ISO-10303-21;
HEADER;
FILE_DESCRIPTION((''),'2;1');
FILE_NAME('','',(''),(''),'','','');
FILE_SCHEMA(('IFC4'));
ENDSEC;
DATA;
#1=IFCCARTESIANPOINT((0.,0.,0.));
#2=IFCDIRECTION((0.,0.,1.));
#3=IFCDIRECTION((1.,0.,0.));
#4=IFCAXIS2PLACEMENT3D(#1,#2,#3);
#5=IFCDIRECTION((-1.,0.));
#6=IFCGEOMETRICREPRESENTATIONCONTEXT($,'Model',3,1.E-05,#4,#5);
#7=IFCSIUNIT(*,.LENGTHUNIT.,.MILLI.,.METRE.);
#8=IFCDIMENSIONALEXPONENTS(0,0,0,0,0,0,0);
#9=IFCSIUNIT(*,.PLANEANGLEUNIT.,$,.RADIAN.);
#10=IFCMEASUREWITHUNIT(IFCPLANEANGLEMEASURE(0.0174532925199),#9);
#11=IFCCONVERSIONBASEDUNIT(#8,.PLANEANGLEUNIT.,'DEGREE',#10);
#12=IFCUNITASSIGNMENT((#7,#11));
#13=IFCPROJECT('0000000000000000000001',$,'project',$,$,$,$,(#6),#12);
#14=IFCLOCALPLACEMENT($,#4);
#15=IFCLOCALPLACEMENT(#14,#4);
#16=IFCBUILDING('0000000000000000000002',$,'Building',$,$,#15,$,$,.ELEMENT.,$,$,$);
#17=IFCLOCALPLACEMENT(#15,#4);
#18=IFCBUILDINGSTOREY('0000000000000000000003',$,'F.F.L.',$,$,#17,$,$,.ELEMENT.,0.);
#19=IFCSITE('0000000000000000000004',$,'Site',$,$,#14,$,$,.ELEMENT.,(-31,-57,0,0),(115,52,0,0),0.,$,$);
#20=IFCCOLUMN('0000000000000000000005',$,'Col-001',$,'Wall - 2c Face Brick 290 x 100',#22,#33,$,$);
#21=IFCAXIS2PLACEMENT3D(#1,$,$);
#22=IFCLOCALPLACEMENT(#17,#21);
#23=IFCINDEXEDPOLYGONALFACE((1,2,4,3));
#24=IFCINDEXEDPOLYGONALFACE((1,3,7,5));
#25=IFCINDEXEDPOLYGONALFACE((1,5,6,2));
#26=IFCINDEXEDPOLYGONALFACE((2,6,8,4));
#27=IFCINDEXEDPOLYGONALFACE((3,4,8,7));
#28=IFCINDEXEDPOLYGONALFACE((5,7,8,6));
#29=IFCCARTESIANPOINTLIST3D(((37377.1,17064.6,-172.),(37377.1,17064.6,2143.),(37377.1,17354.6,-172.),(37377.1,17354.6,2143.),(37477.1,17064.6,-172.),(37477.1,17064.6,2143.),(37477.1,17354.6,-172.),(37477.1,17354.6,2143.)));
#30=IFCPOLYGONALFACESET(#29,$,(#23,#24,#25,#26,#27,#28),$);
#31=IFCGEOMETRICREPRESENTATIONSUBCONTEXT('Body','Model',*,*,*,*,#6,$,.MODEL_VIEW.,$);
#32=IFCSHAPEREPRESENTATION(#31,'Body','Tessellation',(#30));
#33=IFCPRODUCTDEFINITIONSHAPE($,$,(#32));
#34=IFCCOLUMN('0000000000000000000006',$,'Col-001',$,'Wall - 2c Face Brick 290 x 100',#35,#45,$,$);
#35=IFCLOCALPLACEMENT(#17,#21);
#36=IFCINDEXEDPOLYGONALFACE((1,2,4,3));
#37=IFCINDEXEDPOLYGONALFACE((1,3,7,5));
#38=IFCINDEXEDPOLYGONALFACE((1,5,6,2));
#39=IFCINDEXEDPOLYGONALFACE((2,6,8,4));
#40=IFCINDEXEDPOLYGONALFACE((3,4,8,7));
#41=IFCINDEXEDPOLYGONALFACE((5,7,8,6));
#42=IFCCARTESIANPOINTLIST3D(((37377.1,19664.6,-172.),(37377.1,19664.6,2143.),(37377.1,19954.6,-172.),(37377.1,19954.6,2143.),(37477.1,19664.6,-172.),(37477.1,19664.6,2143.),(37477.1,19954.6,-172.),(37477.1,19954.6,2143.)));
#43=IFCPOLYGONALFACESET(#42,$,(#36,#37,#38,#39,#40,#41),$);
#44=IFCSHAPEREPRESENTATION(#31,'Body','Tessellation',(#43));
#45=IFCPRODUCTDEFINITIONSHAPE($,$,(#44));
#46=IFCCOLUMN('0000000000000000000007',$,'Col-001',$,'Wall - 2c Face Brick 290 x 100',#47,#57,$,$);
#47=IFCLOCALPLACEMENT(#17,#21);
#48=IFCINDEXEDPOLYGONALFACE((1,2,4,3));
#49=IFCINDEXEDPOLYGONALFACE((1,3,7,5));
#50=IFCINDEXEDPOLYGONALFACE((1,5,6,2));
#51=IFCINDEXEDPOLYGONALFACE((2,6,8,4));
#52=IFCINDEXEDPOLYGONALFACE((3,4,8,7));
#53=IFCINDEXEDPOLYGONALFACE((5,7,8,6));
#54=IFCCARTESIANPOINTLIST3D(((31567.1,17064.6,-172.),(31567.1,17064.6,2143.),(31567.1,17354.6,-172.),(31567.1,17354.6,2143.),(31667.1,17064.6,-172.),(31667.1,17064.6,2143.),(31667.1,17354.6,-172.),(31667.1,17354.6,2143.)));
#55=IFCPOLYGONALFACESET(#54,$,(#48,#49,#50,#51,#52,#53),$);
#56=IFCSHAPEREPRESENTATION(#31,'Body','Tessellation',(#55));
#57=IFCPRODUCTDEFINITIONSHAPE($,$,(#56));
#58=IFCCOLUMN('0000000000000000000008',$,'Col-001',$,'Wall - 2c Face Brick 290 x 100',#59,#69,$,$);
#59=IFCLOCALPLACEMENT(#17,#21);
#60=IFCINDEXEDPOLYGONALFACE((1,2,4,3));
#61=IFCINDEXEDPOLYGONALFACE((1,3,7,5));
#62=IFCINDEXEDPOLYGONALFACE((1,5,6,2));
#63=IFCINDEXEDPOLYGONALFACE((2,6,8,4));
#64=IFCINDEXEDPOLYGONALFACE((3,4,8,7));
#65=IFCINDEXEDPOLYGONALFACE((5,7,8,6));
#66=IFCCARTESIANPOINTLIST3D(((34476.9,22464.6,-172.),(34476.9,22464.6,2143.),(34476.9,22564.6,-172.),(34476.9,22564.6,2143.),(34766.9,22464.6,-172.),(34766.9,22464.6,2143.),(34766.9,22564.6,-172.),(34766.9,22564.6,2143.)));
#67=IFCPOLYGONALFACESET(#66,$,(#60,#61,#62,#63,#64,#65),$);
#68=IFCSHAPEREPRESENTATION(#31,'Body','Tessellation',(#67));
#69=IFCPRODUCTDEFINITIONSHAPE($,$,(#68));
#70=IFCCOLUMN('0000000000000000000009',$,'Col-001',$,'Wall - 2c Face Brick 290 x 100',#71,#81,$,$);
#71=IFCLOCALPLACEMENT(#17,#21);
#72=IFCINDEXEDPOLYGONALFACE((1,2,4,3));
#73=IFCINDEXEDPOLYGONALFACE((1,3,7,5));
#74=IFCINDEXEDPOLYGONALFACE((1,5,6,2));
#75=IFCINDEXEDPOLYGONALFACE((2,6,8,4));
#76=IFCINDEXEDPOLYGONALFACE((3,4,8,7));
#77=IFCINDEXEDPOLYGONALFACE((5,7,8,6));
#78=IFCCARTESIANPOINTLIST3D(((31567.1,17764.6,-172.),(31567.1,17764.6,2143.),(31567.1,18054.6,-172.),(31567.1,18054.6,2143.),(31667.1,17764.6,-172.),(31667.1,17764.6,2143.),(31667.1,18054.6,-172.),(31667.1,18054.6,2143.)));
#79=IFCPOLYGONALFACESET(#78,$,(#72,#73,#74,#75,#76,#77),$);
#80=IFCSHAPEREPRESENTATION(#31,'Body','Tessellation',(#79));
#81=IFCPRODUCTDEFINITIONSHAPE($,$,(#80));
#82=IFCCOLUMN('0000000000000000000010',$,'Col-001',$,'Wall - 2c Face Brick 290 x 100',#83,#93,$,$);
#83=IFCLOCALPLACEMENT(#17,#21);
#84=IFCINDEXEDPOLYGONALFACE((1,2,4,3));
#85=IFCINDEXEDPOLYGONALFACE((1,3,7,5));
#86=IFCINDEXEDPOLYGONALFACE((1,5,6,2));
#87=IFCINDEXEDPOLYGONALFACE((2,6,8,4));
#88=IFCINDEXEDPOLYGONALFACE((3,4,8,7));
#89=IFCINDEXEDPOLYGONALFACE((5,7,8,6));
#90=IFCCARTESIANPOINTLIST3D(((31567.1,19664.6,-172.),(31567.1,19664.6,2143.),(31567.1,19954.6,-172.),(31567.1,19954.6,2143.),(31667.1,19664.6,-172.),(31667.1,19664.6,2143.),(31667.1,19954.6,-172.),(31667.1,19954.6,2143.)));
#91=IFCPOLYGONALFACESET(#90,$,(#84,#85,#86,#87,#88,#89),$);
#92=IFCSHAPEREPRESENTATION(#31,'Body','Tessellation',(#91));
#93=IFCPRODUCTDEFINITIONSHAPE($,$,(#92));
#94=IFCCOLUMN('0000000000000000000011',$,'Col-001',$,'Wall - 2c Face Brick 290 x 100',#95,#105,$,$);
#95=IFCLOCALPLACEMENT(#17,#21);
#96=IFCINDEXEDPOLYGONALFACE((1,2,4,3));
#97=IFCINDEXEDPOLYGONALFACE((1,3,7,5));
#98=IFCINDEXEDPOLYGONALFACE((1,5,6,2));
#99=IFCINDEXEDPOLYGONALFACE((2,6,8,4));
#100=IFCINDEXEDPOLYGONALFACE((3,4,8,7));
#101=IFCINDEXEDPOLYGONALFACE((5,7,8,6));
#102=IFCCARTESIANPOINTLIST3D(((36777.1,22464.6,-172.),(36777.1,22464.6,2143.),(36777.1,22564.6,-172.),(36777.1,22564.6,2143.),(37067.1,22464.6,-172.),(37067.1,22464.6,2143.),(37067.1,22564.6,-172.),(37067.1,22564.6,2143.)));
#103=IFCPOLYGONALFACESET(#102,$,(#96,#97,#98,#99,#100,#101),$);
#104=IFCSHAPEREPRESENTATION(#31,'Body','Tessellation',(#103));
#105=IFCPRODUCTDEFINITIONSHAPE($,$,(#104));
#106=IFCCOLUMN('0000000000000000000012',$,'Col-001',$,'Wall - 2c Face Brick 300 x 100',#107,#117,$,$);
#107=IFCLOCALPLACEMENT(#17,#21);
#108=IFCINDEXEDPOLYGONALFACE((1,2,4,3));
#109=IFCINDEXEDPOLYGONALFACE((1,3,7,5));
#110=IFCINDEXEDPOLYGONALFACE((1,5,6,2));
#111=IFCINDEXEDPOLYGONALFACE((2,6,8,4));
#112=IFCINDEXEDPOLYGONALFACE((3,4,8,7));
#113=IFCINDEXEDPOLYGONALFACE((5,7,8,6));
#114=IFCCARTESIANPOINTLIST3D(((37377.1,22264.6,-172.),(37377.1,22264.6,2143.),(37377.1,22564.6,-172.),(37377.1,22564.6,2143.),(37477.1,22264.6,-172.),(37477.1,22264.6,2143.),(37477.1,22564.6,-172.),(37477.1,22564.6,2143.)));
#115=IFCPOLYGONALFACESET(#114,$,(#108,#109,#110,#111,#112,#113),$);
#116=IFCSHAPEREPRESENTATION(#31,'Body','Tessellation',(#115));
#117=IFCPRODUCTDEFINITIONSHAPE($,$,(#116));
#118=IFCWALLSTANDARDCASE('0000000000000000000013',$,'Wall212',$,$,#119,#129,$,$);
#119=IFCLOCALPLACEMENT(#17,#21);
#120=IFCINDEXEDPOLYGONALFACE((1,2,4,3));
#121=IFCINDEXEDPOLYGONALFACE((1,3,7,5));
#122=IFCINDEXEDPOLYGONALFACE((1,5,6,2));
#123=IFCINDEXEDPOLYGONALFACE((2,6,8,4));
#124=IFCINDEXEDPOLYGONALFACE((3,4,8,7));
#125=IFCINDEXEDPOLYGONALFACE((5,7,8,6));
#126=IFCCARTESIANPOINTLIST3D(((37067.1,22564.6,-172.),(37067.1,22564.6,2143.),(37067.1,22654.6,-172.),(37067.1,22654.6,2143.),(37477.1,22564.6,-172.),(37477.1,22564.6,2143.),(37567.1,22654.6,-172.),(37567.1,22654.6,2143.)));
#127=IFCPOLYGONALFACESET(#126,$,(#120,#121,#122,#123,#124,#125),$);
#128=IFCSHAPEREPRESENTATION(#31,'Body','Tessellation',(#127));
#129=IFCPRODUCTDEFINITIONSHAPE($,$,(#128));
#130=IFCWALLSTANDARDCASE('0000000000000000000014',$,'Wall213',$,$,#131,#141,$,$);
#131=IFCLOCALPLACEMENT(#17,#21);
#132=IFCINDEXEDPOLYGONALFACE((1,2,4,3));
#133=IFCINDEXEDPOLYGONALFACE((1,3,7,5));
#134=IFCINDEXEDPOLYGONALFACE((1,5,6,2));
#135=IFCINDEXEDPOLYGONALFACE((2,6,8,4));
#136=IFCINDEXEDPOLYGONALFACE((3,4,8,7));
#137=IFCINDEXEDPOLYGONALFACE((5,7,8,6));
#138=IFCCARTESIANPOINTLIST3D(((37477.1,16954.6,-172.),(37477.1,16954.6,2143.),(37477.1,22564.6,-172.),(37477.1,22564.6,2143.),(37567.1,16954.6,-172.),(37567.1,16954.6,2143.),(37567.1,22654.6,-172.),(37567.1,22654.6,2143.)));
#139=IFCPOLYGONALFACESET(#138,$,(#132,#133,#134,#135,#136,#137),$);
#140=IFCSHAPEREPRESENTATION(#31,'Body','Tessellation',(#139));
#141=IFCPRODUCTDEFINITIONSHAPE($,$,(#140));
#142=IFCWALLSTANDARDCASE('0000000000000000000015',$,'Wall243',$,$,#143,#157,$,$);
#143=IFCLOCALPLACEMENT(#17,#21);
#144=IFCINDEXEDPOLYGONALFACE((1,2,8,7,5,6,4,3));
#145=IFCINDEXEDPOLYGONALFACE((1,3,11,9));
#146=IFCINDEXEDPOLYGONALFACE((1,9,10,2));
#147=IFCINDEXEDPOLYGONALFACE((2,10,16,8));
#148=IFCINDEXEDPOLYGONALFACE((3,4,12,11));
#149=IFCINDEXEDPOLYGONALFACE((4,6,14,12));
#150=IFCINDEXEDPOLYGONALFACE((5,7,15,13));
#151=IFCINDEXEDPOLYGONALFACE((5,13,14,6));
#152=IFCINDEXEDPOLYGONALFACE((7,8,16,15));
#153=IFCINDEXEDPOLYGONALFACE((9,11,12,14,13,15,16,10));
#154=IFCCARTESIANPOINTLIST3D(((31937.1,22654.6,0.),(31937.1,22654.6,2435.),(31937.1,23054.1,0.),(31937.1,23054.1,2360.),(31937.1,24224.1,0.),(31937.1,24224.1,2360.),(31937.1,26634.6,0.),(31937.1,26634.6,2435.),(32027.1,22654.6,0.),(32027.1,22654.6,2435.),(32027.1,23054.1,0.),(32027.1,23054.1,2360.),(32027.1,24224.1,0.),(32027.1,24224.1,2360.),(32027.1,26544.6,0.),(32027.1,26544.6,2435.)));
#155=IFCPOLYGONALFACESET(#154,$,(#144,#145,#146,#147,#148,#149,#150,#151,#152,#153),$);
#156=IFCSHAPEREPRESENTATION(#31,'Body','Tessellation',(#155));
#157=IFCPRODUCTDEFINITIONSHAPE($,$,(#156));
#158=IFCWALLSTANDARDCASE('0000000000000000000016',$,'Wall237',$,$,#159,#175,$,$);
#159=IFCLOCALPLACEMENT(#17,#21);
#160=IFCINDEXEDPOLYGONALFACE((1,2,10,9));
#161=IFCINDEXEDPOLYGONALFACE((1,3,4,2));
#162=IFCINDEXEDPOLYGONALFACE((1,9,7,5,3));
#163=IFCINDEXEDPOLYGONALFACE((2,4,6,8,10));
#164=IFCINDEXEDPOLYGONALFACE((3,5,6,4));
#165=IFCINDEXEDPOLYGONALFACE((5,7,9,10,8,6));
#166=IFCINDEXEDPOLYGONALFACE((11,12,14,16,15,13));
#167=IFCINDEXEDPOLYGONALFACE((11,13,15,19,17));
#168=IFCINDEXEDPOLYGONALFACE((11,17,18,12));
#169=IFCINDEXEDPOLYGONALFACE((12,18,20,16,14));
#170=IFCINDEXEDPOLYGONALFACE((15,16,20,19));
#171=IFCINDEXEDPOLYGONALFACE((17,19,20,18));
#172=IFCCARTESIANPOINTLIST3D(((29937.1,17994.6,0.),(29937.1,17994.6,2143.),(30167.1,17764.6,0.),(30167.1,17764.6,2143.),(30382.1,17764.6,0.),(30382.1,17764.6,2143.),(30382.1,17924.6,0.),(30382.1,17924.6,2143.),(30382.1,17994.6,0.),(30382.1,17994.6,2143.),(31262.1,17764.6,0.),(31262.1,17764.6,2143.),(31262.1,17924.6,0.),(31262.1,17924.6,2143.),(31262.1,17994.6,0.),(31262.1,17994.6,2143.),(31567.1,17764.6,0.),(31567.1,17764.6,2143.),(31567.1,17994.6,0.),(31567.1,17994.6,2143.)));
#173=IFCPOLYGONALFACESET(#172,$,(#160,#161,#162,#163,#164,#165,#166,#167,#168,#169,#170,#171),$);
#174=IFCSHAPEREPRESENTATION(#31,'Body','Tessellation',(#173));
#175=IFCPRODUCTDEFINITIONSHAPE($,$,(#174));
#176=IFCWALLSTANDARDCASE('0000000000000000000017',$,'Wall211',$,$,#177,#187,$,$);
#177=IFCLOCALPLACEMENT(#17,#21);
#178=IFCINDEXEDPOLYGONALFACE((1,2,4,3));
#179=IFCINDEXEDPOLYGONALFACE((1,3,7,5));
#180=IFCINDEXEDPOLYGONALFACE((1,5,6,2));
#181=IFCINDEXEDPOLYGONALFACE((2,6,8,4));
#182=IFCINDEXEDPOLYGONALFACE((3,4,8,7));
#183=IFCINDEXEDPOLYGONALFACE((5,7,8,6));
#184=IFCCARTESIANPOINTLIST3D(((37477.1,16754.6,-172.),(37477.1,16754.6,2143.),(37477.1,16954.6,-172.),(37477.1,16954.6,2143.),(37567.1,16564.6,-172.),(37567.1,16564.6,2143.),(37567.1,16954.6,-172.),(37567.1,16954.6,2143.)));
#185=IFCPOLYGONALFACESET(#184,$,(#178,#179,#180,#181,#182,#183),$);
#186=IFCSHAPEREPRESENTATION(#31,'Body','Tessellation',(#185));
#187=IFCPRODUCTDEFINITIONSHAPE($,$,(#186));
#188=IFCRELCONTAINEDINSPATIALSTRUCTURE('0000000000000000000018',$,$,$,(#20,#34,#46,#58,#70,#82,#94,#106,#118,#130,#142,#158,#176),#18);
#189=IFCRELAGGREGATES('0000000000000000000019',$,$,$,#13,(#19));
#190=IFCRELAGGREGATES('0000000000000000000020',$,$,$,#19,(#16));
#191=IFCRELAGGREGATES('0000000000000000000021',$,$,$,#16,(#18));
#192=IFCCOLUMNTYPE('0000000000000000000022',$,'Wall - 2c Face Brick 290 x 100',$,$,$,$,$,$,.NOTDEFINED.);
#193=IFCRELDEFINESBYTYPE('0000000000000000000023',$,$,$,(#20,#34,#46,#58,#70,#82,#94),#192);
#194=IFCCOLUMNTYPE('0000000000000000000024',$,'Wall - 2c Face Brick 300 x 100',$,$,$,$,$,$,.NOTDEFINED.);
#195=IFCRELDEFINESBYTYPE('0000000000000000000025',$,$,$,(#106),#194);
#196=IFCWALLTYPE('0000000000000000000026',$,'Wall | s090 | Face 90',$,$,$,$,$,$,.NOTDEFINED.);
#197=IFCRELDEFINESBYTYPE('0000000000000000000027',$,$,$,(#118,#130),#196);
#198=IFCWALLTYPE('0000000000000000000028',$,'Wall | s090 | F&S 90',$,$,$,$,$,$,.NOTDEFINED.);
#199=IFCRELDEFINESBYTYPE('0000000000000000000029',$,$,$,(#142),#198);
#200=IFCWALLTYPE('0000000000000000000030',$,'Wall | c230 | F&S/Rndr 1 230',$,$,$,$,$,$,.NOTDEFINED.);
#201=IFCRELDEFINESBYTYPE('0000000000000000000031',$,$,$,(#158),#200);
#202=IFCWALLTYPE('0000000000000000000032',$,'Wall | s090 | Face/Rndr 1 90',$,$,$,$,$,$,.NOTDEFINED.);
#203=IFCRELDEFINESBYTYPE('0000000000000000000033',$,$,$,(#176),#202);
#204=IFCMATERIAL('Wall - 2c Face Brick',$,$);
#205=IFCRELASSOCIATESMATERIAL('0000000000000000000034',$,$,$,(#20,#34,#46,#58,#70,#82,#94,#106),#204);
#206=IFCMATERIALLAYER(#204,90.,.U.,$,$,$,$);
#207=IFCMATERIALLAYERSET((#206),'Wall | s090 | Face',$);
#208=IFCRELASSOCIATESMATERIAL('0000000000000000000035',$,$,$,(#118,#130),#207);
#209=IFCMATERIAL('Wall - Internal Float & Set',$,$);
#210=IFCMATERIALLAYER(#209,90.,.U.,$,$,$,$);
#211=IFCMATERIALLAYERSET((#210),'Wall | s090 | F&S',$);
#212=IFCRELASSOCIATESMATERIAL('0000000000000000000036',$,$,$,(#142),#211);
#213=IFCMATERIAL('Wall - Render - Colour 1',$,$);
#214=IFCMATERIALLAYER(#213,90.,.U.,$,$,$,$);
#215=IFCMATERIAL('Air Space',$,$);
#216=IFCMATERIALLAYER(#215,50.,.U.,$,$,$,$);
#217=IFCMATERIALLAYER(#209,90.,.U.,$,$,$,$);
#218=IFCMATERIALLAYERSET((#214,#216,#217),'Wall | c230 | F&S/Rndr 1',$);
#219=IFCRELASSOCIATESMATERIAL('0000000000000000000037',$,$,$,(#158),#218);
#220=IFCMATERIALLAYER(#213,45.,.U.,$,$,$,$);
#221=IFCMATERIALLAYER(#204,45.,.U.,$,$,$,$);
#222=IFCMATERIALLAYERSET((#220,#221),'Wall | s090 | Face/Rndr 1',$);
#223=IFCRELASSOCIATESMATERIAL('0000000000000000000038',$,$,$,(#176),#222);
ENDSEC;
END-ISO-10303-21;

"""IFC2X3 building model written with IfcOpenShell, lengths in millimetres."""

from ifc_helpers import new_model, entity, si_unit, converted_unit, direction, frame, origin_with_axes, origin_2d_with_axis, place, context, subcontext, project, spatial, polyline, rectangle, outline, extrude, material, layer, layer_set, layer_usage, type_object, element, save


model = new_model("IFC2X3")

# Units and contexts
model_context = context("Model", 3, precision=1e-05, world=origin_with_axes(), true_north=direction((-1.0, 0.0)))
body_context = subcontext(model_context, "Body", "Model", "MODEL_VIEW")
ifc_project = project(units=[si_unit("LENGTHUNIT", "METRE", prefix="MILLI"), converted_unit("PLANEANGLEUNIT", "DEGREE", entity("IfcPlaneAngleMeasure", 0.0174532925199), si_unit("PLANEANGLEUNIT", "RADIAN"), dimensions=[0, 0, 0, 0, 0, 0, 0])], contexts=[model_context])

# Site, building, storey
site_placement = place(None, origin_with_axes())
site = spatial("IfcSite", under=ifc_project, at=site_placement, Name="Site", CompositionType="ELEMENT", RefLatitude=(-31, -57, 0, 0), RefLongitude=(115, 52, 0, 0), RefElevation=0.0)
building_placement = place(site_placement, origin_with_axes())
building = spatial("IfcBuilding", under=site, at=building_placement, Name="Building", CompositionType="ELEMENT")
storey_placement = place(building_placement, origin_with_axes())
storey = spatial("IfcBuildingStorey", under=building, at=storey_placement, Name="F.F.L.", CompositionType="ELEMENT", Elevation=0.0)

# Columns
ifc_material_1 = material(Name="Wall - 2c Face Brick")
column_type_1 = type_object("IfcColumnType", Name="Wall - 2c Face Brick 290 x 100", PredefinedType="NOTDEFINED")
for number, where, z_axis, x_axis, name in (
    (1, (37427.1, 17209.6, -172.0), (0.0, 0.0, 1.0), (0.0, 1.0, 0.0), "Col-001"),
    (2, (37427.1, 19809.6, -172.0), (0.0, 0.0, 1.0), (0.0, 1.0, 0.0), "Col-001"),
    (3, (31617.1, 17209.6, -172.0), (0.0, 0.0, 1.0), (0.0, 1.0, 0.0), "Col-001"),
    (4, (34621.9, 22514.6, -172.0), (0.0, 0.0, 1.0), (-1.0, 0.0, 0.0), "Col-001"),
    (5, (31617.1, 17909.6, -172.0), (0.0, 0.0, 1.0), (0.0, 1.0, 0.0), "Col-001"),
    (6, (31617.1, 19809.6, -172.0), (0.0, 0.0, 1.0), (0.0, 1.0, 0.0), "Col-001"),
    (7, (36922.1, 22514.6, -172.0), (0.0, 0.0, 1.0), (-1.0, 0.0, 0.0), "Col-001"),
):
    element("IfcColumn", number, at=place(storey_placement, frame(where, z_axis=z_axis, x_axis=x_axis)), inside=storey, type_object=column_type_1, material=ifc_material_1, Name=name, ObjectType="Wall - 2c Face Brick 290 x 100", context=body_context, shape_type="SweptSolid", body=[
        extrude(rectangle(XDim=290.0, YDim=100.0, at=origin_2d_with_axis()), origin_with_axes(), (0.0, 0.0, 1.0), 2315.0),
    ])
column_type_2 = type_object("IfcColumnType", Name="Wall - 2c Face Brick 300 x 100", PredefinedType="NOTDEFINED")
column_placement = place(storey_placement, frame((37427.1, 22414.6, -172.0), z_axis=(0.0, 0.0, 1.0), x_axis=(0.0, 1.0, 0.0)))
element("IfcColumn", 8, at=column_placement, inside=storey, type_object=column_type_2, material=ifc_material_1, Name="Col-001", ObjectType="Wall - 2c Face Brick 300 x 100", context=body_context, shape_type="SweptSolid", body=[
    extrude(rectangle(XDim=300.0, YDim=100.0, at=origin_2d_with_axis()), origin_with_axes(), (0.0, 0.0, 1.0), 2315.0),
])

# Walls
ifc_layer_1 = layer(ifc_material_1, 90.0, ventilated="UNKNOWN")
ifc_layer_set_1 = layer_set([ifc_layer_1], Name="Wall | s090 | Face")
ifc_layer_usage_1 = layer_usage(ifc_layer_set_1, "AXIS2", "NEGATIVE", 0.0)
wall_type_1 = type_object("IfcWallType", Name="Wall | s090 | Face 90", PredefinedType="NOTDEFINED")
wall_1_placement = place(storey_placement, frame((37067.1, 22654.6, -172.0), z_axis=(0.0, 0.0, 1.0), x_axis=(1.0, 0.0, 0.0)))
element("IfcWallStandardCase", 9, at=wall_1_placement, inside=storey, type_object=wall_type_1, material=ifc_layer_usage_1, Name="Wall212", context=body_context, shape_type="SweptSolid", body=[
    extrude(outline(polyline([(0.0, -90.0), (410.0, -90.0), (500.0, 0.0), (0.0, 0.0), (0.0, -90.0)])), origin_with_axes(), (0.0, 0.0, 1.0), 2315.0),
])
ifc_layer_usage_2 = layer_usage(ifc_layer_set_1, "AXIS2", "NEGATIVE", 0.0)
wall_2_placement = place(storey_placement, frame((37567.1, 22654.6, -172.0), z_axis=(0.0, 0.0, 1.0), x_axis=(0.0, -1.0, 0.0)))
element("IfcWallStandardCase", 10, at=wall_2_placement, inside=storey, type_object=wall_type_1, material=ifc_layer_usage_2, Name="Wall213", context=body_context, shape_type="SweptSolid", body=[
    extrude(outline(polyline([(90.0, -90.0), (5700.0, -90.0), (5700.0, 0.0), (0.0, 0.0), (90.0, -90.0)])), origin_with_axes(), (0.0, 0.0, 1.0), 2315.0),
])

# Wall, opening
ifc_material_2 = material(Name="Wall - Internal Float & Set")
ifc_layer_2 = layer(ifc_material_2, 90.0, ventilated="UNKNOWN")
ifc_layer_set_2 = layer_set([ifc_layer_2], Name="Wall | s090 | F&S")
ifc_layer_usage_3 = layer_usage(ifc_layer_set_2, "AXIS2", "POSITIVE", -90.0)
wall_type_2 = type_object("IfcWallType", Name="Wall | s090 | F&S 90", PredefinedType="NOTDEFINED")
wall_3_placement = place(storey_placement, frame((31937.1, 22654.6, 0.0), z_axis=(0.0, 0.0, 1.0), x_axis=(0.0, 1.0, 0.0)))
wall_3 = element("IfcWallStandardCase", 11, at=wall_3_placement, inside=storey, type_object=wall_type_2, material=ifc_layer_usage_3, Name="Wall243", context=body_context, shape_type="SweptSolid", body=[
    extrude(outline(polyline([(0.0, -90.0), (3890.0, -90.0), (3980.0, 0.0), (0.0, 0.0), (0.0, -90.0)])), origin_with_axes(), (0.0, 0.0, 1.0), 2435.0),
])
opening_1_placement = place(wall_3_placement, frame((984.5, 0.0, 0.0), z_axis=(0.0, 0.0, 1.0), x_axis=(1.0, 0.0, 0.0)))
element("IfcOpeningElement", 12, at=opening_1_placement, cuts=wall_3, context=body_context, shape_type="SweptSolid", body=[
    extrude(rectangle(XDim=1170.0, YDim=2360.0, at=origin_2d_with_axis()), frame((0.0, 90.0, 1180.0), z_axis=(0.0, 1.0, 0.0), x_axis=(1.0, 0.0, 0.0)), (0.0, 0.0, -1.0), 180.0),
])

# Wall, opening
ifc_material_3 = material(Name="Wall - Render - Colour 1")
ifc_layer_3 = layer(ifc_material_3, 90.0, ventilated="UNKNOWN")
ifc_material_4 = material(Name="Air Space")
ifc_layer_4 = layer(ifc_material_4, 50.0, ventilated="UNKNOWN")
ifc_layer_5 = layer(ifc_material_2, 90.0, ventilated="UNKNOWN")
ifc_layer_set_3 = layer_set([ifc_layer_3, ifc_layer_4, ifc_layer_5], Name="Wall | c230 | F&S/Rndr 1")
ifc_layer_usage_4 = layer_usage(ifc_layer_set_3, "AXIS2", "NEGATIVE", 0.0)
wall_type_3 = type_object("IfcWallType", Name="Wall | c230 | F&S/Rndr 1 230", PredefinedType="NOTDEFINED")
wall_4_placement = place(storey_placement, frame((31567.1, 17764.6, 0.0), z_axis=(0.0, 0.0, 1.0), x_axis=(-1.0, 0.0, 0.0)))
wall_4 = element("IfcWallStandardCase", 13, at=wall_4_placement, inside=storey, type_object=wall_type_3, material=ifc_layer_usage_4, Name="Wall237", context=body_context, shape_type="SweptSolid", body=[
    extrude(outline(polyline([(0.0, -230.0), (1630.0, -230.0), (1400.0, 0.0), (0.0, 0.0), (0.0, -230.0)])), origin_with_axes(), (0.0, 0.0, 1.0), 2143.0),
])
opening_2_placement = place(wall_4_placement, frame((745.0, 0.0, 0.0), z_axis=(0.0, 0.0, 1.0), x_axis=(1.0, 0.0, 0.0)))
element("IfcOpeningElement", 14, at=opening_2_placement, cuts=wall_4, context=body_context, shape_type="SweptSolid", body=[
    extrude(rectangle(XDim=880.0, YDim=2143.0, at=origin_2d_with_axis()), frame((0.0, -15320.0, 1071.5), z_axis=(0.0, -1.0, 0.0), x_axis=(-1.0, 0.0, 0.0)), (0.0, 0.0, -1.0), 15390.0),
    extrude(rectangle(XDim=880.0, YDim=2143.0, at=origin_2d_with_axis()), frame((0.0, -160.0, 1071.5), z_axis=(0.0, 1.0, 0.0), x_axis=(-1.0, 0.0, 0.0)), (0.0, 0.0, -1.0), 300.0),
])

# Wall
ifc_layer_6 = layer(ifc_material_3, 45.0, ventilated="UNKNOWN")
ifc_layer_7 = layer(ifc_material_1, 45.0, ventilated="UNKNOWN")
ifc_layer_set_4 = layer_set([ifc_layer_6, ifc_layer_7], Name="Wall | s090 | Face/Rndr 1")
ifc_layer_usage_5 = layer_usage(ifc_layer_set_4, "AXIS2", "NEGATIVE", 0.0)
wall_type_4 = type_object("IfcWallType", Name="Wall | s090 | Face/Rndr 1 90", PredefinedType="NOTDEFINED")
wall_5_placement = place(storey_placement, frame((37567.1, 16954.6, -172.0), z_axis=(0.0, 0.0, 1.0), x_axis=(0.0, -1.0, 0.0)))
element("IfcWallStandardCase", 15, at=wall_5_placement, inside=storey, type_object=wall_type_4, material=ifc_layer_usage_5, Name="Wall211", context=body_context, shape_type="SweptSolid", body=[
    extrude(outline(polyline([(0.0, -90.0), (200.0, -90.0), (390.0, 0.0), (0.0, 0.0), (0.0, -90.0)])), origin_with_axes(), (0.0, 0.0, 1.0), 2315.0),
])

save(model, "model.ifc")
